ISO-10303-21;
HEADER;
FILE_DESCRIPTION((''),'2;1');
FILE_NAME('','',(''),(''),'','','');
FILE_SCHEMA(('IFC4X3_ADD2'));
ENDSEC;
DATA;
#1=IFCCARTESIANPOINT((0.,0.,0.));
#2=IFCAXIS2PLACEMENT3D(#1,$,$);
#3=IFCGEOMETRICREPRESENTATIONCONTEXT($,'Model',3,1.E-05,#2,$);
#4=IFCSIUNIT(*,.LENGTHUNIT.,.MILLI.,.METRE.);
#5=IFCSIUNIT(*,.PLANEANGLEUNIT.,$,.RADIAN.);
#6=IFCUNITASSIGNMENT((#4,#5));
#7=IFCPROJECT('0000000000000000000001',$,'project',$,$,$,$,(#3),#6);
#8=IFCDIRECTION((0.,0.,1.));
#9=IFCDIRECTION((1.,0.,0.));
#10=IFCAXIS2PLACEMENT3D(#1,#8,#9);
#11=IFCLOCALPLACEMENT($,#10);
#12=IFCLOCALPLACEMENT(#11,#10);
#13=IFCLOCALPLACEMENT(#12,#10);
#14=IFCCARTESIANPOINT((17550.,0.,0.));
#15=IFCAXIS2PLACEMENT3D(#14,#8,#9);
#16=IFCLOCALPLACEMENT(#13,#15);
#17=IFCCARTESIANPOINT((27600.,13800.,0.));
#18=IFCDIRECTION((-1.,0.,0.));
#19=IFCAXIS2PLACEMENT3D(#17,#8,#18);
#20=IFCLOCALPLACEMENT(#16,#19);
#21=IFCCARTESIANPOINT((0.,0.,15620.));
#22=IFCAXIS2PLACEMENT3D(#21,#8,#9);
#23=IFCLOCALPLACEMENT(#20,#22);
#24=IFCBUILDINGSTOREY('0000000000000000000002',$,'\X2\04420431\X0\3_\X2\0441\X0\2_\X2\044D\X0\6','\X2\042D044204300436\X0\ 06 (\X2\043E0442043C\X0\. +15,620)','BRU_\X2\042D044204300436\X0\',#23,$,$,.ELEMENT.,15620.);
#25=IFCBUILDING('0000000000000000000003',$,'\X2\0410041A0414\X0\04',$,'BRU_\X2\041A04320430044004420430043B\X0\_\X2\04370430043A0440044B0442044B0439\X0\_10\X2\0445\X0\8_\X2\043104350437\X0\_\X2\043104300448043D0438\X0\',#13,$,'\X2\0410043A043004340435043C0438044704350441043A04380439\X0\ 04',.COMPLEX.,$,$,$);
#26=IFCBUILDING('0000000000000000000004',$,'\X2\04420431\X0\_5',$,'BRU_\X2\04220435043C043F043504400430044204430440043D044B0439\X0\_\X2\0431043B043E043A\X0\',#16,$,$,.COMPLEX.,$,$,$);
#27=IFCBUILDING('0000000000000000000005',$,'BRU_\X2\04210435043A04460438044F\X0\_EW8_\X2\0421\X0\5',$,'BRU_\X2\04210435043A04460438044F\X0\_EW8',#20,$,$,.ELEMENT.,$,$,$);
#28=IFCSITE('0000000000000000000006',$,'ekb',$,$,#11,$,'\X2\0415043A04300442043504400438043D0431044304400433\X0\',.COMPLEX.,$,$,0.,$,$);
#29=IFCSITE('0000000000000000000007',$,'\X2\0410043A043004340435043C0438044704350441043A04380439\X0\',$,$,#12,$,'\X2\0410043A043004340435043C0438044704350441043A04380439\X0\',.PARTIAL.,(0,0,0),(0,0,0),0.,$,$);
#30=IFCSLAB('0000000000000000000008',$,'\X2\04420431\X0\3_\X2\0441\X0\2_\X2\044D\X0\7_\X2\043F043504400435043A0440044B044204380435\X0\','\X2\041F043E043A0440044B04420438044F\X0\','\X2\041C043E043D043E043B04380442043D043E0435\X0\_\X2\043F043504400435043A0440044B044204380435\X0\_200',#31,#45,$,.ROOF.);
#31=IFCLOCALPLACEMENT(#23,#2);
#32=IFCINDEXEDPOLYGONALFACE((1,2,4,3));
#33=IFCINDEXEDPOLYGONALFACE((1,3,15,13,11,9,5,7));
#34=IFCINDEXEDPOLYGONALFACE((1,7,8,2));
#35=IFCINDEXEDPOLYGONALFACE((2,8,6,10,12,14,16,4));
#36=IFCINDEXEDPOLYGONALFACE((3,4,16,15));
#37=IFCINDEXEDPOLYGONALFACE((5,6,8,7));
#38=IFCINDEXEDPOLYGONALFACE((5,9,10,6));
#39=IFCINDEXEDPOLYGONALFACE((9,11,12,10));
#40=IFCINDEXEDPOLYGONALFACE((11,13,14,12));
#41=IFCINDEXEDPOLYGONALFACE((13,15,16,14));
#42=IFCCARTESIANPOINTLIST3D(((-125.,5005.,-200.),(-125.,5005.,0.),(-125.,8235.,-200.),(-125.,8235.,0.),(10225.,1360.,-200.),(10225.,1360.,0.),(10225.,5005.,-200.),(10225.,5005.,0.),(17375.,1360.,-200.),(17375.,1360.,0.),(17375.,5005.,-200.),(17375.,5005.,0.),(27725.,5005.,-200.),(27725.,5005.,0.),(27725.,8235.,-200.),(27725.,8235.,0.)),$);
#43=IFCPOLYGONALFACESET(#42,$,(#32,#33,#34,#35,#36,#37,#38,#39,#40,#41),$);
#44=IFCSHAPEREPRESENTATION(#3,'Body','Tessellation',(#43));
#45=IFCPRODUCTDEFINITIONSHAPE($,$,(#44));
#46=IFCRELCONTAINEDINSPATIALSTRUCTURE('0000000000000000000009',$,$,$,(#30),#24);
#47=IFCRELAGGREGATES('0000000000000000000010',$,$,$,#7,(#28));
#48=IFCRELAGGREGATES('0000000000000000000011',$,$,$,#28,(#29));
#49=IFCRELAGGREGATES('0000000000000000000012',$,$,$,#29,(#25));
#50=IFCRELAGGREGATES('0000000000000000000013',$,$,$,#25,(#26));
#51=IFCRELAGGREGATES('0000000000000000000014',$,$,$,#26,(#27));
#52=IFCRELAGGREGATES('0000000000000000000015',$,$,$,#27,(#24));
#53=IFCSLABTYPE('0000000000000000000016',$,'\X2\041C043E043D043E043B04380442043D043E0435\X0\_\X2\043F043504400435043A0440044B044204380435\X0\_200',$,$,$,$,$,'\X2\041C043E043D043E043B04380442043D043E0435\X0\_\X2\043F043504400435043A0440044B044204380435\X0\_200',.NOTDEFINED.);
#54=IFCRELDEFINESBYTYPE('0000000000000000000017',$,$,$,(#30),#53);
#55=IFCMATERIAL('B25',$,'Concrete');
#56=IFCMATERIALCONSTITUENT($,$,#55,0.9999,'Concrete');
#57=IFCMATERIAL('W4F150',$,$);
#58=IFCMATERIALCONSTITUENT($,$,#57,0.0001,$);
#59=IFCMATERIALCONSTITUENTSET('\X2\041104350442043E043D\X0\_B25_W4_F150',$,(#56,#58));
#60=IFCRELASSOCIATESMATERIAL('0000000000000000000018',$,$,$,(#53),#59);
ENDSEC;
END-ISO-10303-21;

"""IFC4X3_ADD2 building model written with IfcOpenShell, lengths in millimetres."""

from ifc_helpers import new_model, si_unit, frame, origin, origin_with_axes, place, context, project, spatial, polyline, outline, extrude, material, constituent, constituent_set, type_object, element, save


model = new_model("IFC4X3_ADD2")

# Units and contexts
model_context = context("Model", 3, precision=1e-05, world=origin())
ifc_project = project(units=[si_unit("LENGTHUNIT", "METRE", prefix="MILLI"), si_unit("PLANEANGLEUNIT", "RADIAN")], contexts=[model_context])

# Sites, buildings, storey
site_1_placement = place(None, origin_with_axes())
site_1 = spatial("IfcSite", under=ifc_project, at=site_1_placement, Name="ekb", LongName="Екатеринбург", CompositionType="COMPLEX", RefElevation=0.0)
site_2_placement = place(site_1_placement, origin_with_axes())
site_2 = spatial("IfcSite", under=site_1, at=site_2_placement, Name="Академический", LongName="Академический", CompositionType="PARTIAL", RefLatitude=(0, 0, 0), RefLongitude=(0, 0, 0), RefElevation=0.0)
building_1_placement = place(site_2_placement, origin_with_axes())
building_1 = spatial("IfcBuilding", under=site_2, at=building_1_placement, Name="АКД04", ObjectType="BRU_Квартал_закрытый_10х8_без_башни", LongName="Академический 04", CompositionType="COMPLEX")
building_2_placement = place(building_1_placement, frame((17550.0, 0.0, 0.0), z_axis=(0.0, 0.0, 1.0), x_axis=(1.0, 0.0, 0.0)))
building_2 = spatial("IfcBuilding", under=building_1, at=building_2_placement, Name="тб_5", ObjectType="BRU_Температурный_блок", CompositionType="COMPLEX")
building_3_placement = place(building_2_placement, frame((27600.0, 13800.0, 0.0), z_axis=(0.0, 0.0, 1.0), x_axis=(-1.0, 0.0, 0.0)))
building_3 = spatial("IfcBuilding", under=building_2, at=building_3_placement, Name="BRU_Секция_EW8_С5", ObjectType="BRU_Секция_EW8", CompositionType="ELEMENT")
storey_placement = place(building_3_placement, frame((0.0, 0.0, 15620.0), z_axis=(0.0, 0.0, 1.0), x_axis=(1.0, 0.0, 0.0)))
storey = spatial("IfcBuildingStorey", under=building_3, at=storey_placement, Name="тб3_с2_э6", Description="Этаж 06 (отм. +15,620)", ObjectType="BRU_Этаж", CompositionType="ELEMENT", Elevation=15620.0)

# Slab
ifc_material_1 = material(Name="B25", Category="Concrete")
ifc_constituent_1 = constituent(ifc_material_1, Category="Concrete", fraction=0.9999)
ifc_material_2 = material(Name="W4F150")
ifc_constituent_2 = constituent(ifc_material_2, fraction=0.0001)
ifc_constituent_set = constituent_set(constituents=[ifc_constituent_1, ifc_constituent_2], Name="Бетон_B25_W4_F150")
slab_type = type_object("IfcSlabType", Name="Монолитное_перекрытие_200", ElementType="Монолитное_перекрытие_200", PredefinedType="NOTDEFINED", material=ifc_constituent_set)
slab_placement = place(storey_placement, frame((0.0, 0.0, -200.0), z_axis=(0.0, 0.0, 1.0), x_axis=(1.0, 0.0, 0.0)))
element("IfcSlab", 1, at=slab_placement, inside=storey, type_object=slab_type, Name="тб3_с2_э7_перекрытие", Description="Покрытия", ObjectType="Монолитное_перекрытие_200", PredefinedType="ROOF", context=model_context, shape_type="SweptSolid", body=[
    extrude(outline(polyline([(-125.0, 5005.0), (-125.0, 8235.0), (27725.0, 8235.0), (27725.0, 5005.0), (17375.0, 5005.0), (17375.0, 1360.0), (10225.0, 1360.0), (10225.0, 5005.0), (-125.0, 5005.0)])), origin_with_axes(), (0.0, 0.0, 1.0), 200.0),
])

save(model, "model.ifc")
